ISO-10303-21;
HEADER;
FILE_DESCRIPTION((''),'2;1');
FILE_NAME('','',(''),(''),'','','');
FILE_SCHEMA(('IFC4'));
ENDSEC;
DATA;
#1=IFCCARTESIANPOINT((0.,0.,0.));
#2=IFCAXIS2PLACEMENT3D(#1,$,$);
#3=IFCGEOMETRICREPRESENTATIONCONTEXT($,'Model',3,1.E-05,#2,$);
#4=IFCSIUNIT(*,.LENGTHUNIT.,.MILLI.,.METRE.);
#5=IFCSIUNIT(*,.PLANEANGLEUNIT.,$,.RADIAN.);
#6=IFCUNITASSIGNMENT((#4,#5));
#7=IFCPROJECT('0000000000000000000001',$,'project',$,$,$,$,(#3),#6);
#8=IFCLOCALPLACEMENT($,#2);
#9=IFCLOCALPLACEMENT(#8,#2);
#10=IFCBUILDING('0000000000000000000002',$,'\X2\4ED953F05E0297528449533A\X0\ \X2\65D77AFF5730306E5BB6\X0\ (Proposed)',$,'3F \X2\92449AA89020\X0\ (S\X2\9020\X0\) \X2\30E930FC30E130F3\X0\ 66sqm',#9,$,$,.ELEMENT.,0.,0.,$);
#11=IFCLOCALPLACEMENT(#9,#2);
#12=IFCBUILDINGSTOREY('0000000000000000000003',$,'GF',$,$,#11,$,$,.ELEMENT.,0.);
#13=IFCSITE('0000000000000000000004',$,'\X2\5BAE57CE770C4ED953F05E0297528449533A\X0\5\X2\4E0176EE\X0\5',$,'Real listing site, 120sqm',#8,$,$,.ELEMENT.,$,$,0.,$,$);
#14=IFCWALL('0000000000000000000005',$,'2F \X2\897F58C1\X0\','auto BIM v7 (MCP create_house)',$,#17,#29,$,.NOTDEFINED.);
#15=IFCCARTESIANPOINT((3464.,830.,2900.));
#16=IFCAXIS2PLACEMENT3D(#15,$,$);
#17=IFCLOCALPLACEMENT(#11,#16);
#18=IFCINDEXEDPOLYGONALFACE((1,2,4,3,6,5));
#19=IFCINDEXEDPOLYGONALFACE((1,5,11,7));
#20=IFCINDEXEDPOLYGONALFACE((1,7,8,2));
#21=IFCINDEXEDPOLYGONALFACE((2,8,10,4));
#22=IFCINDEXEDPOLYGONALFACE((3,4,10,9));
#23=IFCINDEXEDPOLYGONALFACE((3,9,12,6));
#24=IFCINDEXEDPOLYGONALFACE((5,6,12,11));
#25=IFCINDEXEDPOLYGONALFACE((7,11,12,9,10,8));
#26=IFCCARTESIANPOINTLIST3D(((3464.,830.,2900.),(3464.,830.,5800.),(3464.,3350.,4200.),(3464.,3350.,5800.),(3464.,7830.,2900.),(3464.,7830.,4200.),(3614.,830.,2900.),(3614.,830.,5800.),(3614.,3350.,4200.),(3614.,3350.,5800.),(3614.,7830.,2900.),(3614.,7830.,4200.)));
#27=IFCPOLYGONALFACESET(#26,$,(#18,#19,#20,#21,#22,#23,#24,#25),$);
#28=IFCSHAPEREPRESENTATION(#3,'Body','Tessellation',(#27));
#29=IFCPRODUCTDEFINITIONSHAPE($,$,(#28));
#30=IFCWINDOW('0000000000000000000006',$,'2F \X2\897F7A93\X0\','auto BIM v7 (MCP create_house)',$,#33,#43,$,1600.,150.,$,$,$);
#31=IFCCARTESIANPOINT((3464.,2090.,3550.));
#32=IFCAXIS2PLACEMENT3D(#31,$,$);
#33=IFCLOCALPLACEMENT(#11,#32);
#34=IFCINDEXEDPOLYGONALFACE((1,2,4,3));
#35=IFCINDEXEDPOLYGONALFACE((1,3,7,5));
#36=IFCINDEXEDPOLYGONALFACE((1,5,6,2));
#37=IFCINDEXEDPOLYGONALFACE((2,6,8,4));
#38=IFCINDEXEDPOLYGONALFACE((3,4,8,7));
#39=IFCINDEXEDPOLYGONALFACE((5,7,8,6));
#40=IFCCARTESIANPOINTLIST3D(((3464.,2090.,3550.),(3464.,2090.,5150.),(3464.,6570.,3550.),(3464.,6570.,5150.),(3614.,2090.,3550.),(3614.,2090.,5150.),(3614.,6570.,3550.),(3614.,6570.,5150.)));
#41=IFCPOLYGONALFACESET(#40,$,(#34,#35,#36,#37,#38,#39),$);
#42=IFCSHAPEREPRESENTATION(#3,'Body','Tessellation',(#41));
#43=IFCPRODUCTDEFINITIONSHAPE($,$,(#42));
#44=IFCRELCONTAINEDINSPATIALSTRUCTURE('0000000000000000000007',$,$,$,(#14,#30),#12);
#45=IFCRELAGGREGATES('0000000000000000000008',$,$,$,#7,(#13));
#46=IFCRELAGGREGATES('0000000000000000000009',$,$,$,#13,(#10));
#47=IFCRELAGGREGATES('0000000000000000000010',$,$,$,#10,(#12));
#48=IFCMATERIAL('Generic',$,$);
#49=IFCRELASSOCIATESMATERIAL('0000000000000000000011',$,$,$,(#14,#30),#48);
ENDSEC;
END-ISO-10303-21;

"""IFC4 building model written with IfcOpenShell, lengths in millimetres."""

from ifc_helpers import new_model, si_unit, frame, frame_2d, origin, place, context, project, spatial, rectangle, extrude, material, element, fill, save


model = new_model("IFC4")

# Units and contexts
model_context = context("Model", 3, precision=1e-05, world=origin())
ifc_project = project(units=[si_unit("LENGTHUNIT", "METRE", prefix="MILLI"), si_unit("PLANEANGLEUNIT", "RADIAN")], contexts=[model_context])

# Site, building, storey
site_placement = place(None, origin())
site = spatial("IfcSite", under=ifc_project, at=site_placement, Name="宮城県仙台市青葉区5丁目5", ObjectType="Real listing site, 120sqm", CompositionType="ELEMENT", RefElevation=0.0)
building_placement = place(site_placement, origin())
building = spatial("IfcBuilding", under=site, at=building_placement, Name="仙台市青葉区 旗竿地の家 (Proposed)", ObjectType="3F 鉄骨造 (S造) ラーメン 66sqm", CompositionType="ELEMENT", ElevationOfRefHeight=0.0, ElevationOfTerrain=0.0)
storey_placement = place(building_placement, origin())
storey = spatial("IfcBuildingStorey", under=building, at=storey_placement, Name="GF", CompositionType="ELEMENT", Elevation=0.0)

# Shared definitions
ifc_material = material(Name="Generic")

# Wall, opening, window
wall_1_placement = place(storey_placement, frame((3464.0, 830.0, 2900.0)))
wall_1 = element("IfcWall", 1, at=wall_1_placement, inside=storey, material=ifc_material, Name="2F 西壁", Description="auto BIM v7 (MCP create_house)", PredefinedType="NOTDEFINED", context=model_context, shape_type="SweptSolid", body=[
    extrude(rectangle(XDim=150.0, YDim=7000.0, at=frame_2d((75.0, 3500.0))), frame((3464.0, 830.0, 2900.0)), (0.0, 0.0, 1.0), 2900.0),
])
opening_1_placement = place(storey_placement, frame((3464.0, 2090.0, 3550.0)))
opening_1 = element("IfcOpeningElement", 2, at=opening_1_placement, cuts=wall_1, PredefinedType="NOTDEFINED", context=model_context, shape_type="SweptSolid", body=[
    extrude(rectangle(XDim=150.0, YDim=4480.0, at=frame_2d((75.0, 2240.0))), frame((3464.0, 2090.0, 3550.0)), (0.0, 0.0, 1.0), 1600.0),
])
window_1_placement = place(storey_placement, frame((3464.0, 2090.0, 3550.0)))
window_1 = element("IfcWindow", 3, at=window_1_placement, inside=storey, material=ifc_material, Name="2F 西窓", Description="auto BIM v7 (MCP create_house)", OverallHeight=1600.0, OverallWidth=150.0, context=model_context, shape_type="SweptSolid", body=[
    extrude(rectangle(XDim=150.0, YDim=4480.0, at=frame_2d((75.0, 2240.0))), frame((3464.0, 2090.0, 3550.0)), (0.0, 0.0, 1.0), 1600.0),
])
fill(opening_1, window_1)

save(model, "model.ifc")
